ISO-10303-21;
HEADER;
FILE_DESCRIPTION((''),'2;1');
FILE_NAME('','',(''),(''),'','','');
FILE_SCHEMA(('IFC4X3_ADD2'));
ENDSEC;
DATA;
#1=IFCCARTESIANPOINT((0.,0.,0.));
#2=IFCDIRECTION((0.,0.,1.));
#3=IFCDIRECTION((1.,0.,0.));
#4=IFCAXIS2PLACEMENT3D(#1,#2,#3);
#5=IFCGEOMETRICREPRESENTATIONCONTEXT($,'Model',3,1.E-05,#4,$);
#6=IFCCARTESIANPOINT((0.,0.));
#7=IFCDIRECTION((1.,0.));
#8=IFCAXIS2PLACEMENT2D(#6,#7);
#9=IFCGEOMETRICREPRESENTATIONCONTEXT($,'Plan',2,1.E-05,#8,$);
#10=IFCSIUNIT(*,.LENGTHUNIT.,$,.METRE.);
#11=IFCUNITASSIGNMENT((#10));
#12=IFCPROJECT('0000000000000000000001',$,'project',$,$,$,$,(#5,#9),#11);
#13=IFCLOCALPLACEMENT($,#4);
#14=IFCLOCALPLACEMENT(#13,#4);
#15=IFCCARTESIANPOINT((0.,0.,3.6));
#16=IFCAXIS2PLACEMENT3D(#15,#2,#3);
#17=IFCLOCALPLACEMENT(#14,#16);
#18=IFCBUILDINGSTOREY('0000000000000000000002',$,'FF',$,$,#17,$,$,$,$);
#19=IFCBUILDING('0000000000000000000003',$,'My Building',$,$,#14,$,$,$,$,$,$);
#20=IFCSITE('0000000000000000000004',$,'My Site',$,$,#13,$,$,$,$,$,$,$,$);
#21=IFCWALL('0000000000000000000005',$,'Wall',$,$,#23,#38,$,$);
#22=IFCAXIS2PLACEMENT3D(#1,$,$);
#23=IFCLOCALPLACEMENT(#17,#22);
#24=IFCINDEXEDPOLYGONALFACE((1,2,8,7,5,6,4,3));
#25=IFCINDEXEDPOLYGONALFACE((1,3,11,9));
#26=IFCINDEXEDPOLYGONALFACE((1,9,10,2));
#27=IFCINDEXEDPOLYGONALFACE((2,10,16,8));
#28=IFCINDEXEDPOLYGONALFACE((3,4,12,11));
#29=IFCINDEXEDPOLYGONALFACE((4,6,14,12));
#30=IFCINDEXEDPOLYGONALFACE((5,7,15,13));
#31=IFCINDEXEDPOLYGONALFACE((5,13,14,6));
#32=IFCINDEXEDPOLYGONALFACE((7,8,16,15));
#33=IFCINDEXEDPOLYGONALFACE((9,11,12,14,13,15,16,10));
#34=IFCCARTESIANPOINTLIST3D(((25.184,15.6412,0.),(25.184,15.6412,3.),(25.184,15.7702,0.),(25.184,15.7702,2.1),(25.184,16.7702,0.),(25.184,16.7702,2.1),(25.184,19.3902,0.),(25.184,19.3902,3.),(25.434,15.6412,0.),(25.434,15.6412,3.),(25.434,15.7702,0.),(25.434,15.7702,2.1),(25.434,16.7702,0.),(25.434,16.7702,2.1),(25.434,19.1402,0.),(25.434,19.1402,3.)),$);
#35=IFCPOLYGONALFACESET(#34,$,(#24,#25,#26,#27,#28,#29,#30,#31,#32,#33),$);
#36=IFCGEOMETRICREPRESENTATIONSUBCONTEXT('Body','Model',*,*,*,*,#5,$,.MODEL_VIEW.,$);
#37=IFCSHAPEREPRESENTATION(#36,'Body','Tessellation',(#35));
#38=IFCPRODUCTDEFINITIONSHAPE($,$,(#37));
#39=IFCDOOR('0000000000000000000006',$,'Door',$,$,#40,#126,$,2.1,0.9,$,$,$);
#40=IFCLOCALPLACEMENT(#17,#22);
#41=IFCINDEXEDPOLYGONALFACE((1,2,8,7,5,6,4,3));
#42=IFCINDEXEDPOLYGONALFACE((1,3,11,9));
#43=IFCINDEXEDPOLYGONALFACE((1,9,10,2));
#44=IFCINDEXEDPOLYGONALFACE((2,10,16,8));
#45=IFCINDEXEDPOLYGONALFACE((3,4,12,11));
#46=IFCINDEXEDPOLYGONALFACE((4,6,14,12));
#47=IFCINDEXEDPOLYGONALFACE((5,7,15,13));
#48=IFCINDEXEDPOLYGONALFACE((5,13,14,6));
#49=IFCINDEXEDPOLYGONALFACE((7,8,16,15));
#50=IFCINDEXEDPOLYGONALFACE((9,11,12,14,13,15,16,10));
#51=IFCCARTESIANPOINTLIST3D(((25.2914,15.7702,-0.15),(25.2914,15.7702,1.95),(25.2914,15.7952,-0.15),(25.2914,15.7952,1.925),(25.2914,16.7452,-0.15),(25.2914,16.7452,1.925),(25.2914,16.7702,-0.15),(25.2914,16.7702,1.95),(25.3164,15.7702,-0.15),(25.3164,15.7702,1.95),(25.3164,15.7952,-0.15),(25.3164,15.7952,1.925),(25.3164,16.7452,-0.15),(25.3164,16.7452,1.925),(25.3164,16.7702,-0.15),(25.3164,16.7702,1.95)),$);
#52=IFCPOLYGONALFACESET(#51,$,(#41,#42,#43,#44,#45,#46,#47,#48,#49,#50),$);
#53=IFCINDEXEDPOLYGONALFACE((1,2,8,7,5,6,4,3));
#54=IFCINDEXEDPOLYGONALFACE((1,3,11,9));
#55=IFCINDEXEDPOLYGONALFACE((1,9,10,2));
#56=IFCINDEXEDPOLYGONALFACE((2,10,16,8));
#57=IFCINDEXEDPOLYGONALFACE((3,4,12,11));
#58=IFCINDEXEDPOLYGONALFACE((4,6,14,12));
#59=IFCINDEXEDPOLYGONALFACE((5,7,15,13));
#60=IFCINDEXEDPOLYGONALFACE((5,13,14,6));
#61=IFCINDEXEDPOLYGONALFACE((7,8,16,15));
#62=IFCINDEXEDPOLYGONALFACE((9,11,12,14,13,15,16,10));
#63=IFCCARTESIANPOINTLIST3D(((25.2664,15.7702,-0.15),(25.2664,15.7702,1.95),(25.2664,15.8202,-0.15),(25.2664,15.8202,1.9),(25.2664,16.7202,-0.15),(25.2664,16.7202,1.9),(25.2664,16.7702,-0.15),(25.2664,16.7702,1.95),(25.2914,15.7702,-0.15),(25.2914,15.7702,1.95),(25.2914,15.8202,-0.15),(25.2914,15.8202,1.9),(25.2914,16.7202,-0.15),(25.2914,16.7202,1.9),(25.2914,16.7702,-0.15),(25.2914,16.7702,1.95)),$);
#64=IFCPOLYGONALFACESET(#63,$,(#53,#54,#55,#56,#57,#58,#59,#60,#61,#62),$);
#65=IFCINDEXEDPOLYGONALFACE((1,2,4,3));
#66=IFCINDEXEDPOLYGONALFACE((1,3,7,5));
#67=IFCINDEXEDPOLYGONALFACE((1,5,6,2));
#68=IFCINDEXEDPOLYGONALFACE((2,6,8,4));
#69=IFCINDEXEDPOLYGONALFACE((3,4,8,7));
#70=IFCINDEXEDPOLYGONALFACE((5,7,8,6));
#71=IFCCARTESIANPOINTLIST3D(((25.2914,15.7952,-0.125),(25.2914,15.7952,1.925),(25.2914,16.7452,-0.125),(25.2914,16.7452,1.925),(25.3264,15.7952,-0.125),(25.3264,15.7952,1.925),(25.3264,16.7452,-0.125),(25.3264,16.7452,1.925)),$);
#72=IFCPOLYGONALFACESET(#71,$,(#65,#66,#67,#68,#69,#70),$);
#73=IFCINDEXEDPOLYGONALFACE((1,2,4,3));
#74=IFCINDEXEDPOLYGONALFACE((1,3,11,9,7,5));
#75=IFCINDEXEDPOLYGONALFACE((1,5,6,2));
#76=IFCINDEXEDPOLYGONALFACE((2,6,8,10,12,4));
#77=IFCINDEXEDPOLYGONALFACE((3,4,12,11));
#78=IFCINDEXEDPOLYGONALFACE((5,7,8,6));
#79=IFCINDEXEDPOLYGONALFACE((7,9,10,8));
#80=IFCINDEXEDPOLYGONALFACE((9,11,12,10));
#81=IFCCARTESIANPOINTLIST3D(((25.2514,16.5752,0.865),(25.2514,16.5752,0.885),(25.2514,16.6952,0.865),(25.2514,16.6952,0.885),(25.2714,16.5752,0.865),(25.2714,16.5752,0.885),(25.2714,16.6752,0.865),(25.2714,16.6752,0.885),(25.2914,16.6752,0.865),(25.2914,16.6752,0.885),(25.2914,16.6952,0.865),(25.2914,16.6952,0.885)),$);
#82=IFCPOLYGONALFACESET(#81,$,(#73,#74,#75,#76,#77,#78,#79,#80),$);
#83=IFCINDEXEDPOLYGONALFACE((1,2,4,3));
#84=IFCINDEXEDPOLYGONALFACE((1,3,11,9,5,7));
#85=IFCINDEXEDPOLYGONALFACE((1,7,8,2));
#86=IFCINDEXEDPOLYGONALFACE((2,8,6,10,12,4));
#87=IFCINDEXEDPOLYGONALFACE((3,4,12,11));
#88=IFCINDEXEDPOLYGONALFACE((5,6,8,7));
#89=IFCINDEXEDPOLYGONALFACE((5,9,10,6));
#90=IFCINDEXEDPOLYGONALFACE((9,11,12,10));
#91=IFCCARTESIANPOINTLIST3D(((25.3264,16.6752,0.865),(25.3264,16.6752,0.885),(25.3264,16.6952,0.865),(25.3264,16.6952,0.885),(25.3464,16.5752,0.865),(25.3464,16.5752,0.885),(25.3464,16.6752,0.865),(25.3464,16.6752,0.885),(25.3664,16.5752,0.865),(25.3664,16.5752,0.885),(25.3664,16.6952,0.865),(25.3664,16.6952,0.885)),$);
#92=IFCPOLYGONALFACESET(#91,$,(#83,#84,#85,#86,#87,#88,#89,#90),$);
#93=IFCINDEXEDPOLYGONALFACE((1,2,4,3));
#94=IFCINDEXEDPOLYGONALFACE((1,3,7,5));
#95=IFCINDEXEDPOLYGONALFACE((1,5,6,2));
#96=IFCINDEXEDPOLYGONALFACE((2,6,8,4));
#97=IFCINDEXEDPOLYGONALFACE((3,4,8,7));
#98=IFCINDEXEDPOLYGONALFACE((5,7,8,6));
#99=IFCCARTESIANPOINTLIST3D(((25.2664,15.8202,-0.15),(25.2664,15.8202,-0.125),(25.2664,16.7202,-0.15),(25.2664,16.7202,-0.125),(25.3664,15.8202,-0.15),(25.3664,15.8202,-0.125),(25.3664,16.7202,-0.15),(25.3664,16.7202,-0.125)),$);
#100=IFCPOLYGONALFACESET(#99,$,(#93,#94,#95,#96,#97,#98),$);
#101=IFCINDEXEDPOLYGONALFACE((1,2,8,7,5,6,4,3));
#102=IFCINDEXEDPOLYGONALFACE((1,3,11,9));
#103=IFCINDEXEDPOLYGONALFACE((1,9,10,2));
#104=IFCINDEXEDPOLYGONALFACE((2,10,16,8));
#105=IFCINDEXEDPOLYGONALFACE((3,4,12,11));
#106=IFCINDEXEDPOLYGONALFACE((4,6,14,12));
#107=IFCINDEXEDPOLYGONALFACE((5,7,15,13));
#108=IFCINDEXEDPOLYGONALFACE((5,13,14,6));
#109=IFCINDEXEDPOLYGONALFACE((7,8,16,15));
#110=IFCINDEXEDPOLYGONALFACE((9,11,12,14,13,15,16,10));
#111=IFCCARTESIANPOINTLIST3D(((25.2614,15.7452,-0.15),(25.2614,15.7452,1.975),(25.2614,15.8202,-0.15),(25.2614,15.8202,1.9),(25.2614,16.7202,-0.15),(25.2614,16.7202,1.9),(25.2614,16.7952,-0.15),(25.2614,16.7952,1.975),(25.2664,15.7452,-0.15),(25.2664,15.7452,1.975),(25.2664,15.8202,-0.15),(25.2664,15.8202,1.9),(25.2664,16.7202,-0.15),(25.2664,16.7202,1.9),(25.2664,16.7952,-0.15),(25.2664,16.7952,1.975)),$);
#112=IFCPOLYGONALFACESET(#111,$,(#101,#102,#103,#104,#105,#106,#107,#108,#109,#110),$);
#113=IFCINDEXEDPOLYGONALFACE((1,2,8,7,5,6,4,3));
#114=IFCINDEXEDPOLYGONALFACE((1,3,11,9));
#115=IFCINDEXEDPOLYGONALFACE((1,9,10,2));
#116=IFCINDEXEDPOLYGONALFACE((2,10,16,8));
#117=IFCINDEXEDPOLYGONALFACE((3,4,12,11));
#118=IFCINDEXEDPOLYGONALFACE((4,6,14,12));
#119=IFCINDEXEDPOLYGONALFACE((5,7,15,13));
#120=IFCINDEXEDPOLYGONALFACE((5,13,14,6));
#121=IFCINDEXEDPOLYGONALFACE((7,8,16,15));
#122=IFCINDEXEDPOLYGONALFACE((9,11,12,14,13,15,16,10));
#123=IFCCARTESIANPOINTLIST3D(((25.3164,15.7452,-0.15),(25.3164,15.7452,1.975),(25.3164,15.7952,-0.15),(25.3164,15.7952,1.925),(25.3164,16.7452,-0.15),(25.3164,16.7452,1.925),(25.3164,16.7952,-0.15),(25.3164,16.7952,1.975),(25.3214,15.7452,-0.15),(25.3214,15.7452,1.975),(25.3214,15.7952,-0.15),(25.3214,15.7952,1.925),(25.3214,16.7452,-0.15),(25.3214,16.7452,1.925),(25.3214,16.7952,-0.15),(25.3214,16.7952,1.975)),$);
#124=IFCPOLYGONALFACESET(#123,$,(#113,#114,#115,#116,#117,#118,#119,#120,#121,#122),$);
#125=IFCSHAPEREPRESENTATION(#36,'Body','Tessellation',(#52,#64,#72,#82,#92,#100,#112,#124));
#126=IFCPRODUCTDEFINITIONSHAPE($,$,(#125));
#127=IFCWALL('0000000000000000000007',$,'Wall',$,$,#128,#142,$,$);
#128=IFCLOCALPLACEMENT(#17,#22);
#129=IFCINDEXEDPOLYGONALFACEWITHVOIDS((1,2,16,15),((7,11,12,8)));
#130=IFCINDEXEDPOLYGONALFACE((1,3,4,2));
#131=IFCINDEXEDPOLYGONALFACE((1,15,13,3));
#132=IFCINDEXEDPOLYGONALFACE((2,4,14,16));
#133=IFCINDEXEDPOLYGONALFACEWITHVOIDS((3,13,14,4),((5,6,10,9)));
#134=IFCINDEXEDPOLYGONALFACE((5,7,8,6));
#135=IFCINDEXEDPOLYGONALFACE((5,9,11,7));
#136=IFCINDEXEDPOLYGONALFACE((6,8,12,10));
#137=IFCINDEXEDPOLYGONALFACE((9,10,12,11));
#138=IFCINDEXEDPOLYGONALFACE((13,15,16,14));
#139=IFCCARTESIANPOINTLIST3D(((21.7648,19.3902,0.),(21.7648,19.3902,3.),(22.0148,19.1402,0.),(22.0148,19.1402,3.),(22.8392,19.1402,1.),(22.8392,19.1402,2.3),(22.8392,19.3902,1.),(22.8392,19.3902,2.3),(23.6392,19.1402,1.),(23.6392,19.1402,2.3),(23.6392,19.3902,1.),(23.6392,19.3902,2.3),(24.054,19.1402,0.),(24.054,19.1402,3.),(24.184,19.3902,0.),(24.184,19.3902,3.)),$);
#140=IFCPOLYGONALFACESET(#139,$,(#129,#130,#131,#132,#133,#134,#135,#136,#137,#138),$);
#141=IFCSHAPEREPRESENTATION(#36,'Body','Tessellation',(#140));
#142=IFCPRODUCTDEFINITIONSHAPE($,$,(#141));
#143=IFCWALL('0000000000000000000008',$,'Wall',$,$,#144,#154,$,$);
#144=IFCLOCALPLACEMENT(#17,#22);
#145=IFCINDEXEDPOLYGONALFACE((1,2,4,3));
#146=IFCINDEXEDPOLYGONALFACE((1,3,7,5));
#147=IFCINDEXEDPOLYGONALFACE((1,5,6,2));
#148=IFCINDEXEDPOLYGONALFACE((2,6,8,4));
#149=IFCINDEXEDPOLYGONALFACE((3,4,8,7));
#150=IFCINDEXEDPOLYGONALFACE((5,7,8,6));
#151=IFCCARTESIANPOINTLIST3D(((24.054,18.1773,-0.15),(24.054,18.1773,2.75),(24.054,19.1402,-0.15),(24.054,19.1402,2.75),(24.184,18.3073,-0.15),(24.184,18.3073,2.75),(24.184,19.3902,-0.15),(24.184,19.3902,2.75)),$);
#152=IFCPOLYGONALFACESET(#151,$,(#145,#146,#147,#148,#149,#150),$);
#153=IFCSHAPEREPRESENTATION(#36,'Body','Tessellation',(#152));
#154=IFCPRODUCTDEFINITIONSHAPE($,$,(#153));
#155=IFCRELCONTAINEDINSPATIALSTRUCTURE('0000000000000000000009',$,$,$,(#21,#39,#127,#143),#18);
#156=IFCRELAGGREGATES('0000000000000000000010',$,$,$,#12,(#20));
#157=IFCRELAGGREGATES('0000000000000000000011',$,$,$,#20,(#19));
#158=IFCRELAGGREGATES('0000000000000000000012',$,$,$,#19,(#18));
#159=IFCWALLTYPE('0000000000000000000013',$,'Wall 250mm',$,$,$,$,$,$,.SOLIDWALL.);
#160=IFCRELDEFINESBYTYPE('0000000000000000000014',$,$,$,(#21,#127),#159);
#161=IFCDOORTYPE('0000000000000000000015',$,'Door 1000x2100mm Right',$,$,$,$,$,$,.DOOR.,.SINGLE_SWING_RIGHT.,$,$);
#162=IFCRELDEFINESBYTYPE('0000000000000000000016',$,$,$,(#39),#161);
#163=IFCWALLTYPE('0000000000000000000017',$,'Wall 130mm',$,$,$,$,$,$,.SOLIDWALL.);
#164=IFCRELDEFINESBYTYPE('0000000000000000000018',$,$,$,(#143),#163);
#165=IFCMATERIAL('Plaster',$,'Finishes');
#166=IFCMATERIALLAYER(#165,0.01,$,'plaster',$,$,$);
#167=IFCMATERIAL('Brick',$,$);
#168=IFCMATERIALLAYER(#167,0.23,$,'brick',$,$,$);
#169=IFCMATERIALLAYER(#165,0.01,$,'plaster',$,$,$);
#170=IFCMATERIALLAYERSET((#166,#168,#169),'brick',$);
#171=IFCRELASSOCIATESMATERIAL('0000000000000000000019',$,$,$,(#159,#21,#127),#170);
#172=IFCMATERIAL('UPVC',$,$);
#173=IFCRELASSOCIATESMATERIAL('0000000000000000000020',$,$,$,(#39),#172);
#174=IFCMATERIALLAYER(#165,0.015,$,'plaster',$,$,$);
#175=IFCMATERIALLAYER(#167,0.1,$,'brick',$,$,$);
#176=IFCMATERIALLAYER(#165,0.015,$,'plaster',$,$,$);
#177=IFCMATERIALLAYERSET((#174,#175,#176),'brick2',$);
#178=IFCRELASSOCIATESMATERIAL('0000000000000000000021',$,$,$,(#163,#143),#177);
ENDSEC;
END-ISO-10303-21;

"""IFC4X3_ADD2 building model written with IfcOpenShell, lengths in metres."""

from ifc_helpers import new_model, entity, si_unit, frame, origin_with_axes, origin_2d_with_axis, place, context, subcontext, project, spatial, line, indexed_curve, outline, extrude, shape, source, transform, mapped, material, layer, layer_set, layer_usage, type_object, type_shapes, element, fill, save


model = new_model("IFC4X3_ADD2")

# Units and contexts
model_context = context("Model", 3, precision=1e-05, world=origin_with_axes())
plan_context = context("Plan", 2, precision=1e-05, world=origin_2d_with_axis())
body_context_1 = subcontext(model_context, "Body", "Model", "MODEL_VIEW")
body_context_2 = subcontext(plan_context, "Body", "Plan", "PLAN_VIEW")
ifc_project = project(units=[si_unit("LENGTHUNIT", "METRE")], contexts=[model_context, plan_context])

# Site, building, storey
site_placement = place(None, origin_with_axes())
site = spatial("IfcSite", under=ifc_project, at=site_placement, Name="My Site")
building_placement = place(site_placement, origin_with_axes())
building = spatial("IfcBuilding", under=site, at=building_placement, Name="My Building")
storey_placement = place(building_placement, frame((0.0, 0.0, 3.6), z_axis=(0.0, 0.0, 1.0), x_axis=(1.0, 0.0, 0.0)))
storey = spatial("IfcBuildingStorey", under=building, at=storey_placement, Name="FF")

# Shared definitions
ifc_material_1 = material(Name="UPVC")

# Shared definitions
ifc_material_2 = material(Name="Plaster", Category="Finishes")
ifc_layer_1 = layer(ifc_material_2, 0.01, Name="plaster")
ifc_material_3 = material(Name="Brick")
ifc_layer_2 = layer(ifc_material_3, 0.23, Name="brick")
ifc_layer_3 = layer(ifc_material_2, 0.01, Name="plaster")
ifc_layer_set_1 = layer_set([ifc_layer_1, ifc_layer_2, ifc_layer_3], Name="brick")
wall_type_1 = type_object("IfcWallType", Name="Wall 250mm", PredefinedType="SOLIDWALL", material=ifc_layer_set_1)
shared_shape_1 = source(origin_with_axes(), body_context_1, "Body", "SweptSolid", [
    extrude(outline(indexed_curve([(0.0, 0.0), (0.8, 0.0), (0.8, 1.3), (0.0, 1.3)], segments=[line(1, 2, 3, 4, 1)])), frame((-0.4, -0.6, 0.0), z_axis=(0.0, -1.0, 0.0), x_axis=(1.0, 0.0, 0.0)), (0.0, 0.0, -1.0), 1.2),
])

# Wall, opening, door
ifc_layer_usage_1 = layer_usage(ifc_layer_set_1, "AXIS2", "POSITIVE", 0.0)
wall_1_placement = place(storey_placement, frame((25.434, 15.3912, 0.0), z_axis=(0.0, 0.0, 1.0), x_axis=(0.000001, 1.0, 0.0)))
wall_1 = element("IfcWall", 1, at=wall_1_placement, inside=storey, type_object=wall_type_1, material=ifc_layer_usage_1, Name="Wall", context=body_context_1, shape_type="SweptSolid", body=[
    extrude(outline(indexed_curve([(0.25, 0.0), (0.25, 0.25), (3.999, 0.25), (3.749, 0.0)], segments=[line(1, 2, 3, 4, 1)])), origin_with_axes(), (0.0, 0.0, 1.0), 3.0),
])
shared_shape_2 = source(origin_with_axes(), body_context_1, "Body", "SweptSolid", [
    extrude(outline(indexed_curve([(0.0, 2.1), (1.0, 2.1), (1.0, -0.05), (0.0, -0.05), (0.0, 2.1)])), frame((0.0, -0.6, 0.0), z_axis=(0.0, -1.0, 0.0), x_axis=(1.0, 0.0, 0.0)), (0.0, 0.0, -1.0), 1.2),
])
opening_1_placement = place(wall_1_placement, frame((1.379, 0.1676, 0.0), z_axis=(0.0, 0.0, 1.0), x_axis=(-1.0, 0.0, 0.0)))
opening_1 = element("IfcOpeningElement", 2, at=opening_1_placement, cuts=wall_1, PredefinedType="OPENING", context=body_context_1, shape_type="MappedRepresentation", body=[
    mapped(shared_shape_2, transform((0.0, 0.0, 0.0), x_axis=(1.0, 0.0, 0.0), y_axis=(0.0, 1.0, 0.0), z_axis=(0.0, 0.0, 1.0), scale=1.0)),
])
door_type_1 = type_object("IfcDoorType", Name="Door 1000x2100mm Right", OperationType="SINGLE_SWING_RIGHT", PredefinedType="DOOR")
shared_shape_3 = source(origin_with_axes(), body_context_1, "Body", "SweptSolid", [
    extrude(outline(indexed_curve([(0.0, 0.0), (0.0, 2.1), (1.0, 2.1), (1.0, 0.0), (0.975, 0.0), (0.975, 2.075), (0.025, 2.075), (0.025, 0.0)], segments=[line(1, 2, 3, 4, 5, 6, 7, 8, 1)])), frame((0.0, 0.025, 0.0), z_axis=(0.0, -1.0, 0.0), x_axis=(1.0, 0.0, 0.0)), (0.0, 0.0, -1.0), 0.025),
    extrude(outline(indexed_curve([(0.0, 0.0), (0.0, 2.1), (1.0, 2.1), (1.0, 0.0), (0.95, 0.0), (0.95, 2.05), (0.05, 2.05), (0.05, 0.0)], segments=[line(1, 2, 3, 4, 5, 6, 7, 8, 1)])), frame((0.0, 0.0, 0.0), z_axis=(0.0, -1.0, 0.0), x_axis=(1.0, 0.0, 0.0)), (0.0, 0.0, -1.0), 0.025),
    extrude(outline(indexed_curve([(0.0, 0.0), (0.95, 0.0), (0.95, 0.035), (0.0, 0.035)], segments=[line(1, 2, 3, 4, 1)])), frame((0.025, 0.025, 0.025), z_axis=(0.0, 0.0, 1.0), x_axis=(1.0, 0.0, 0.0)), (0.0, 0.0, 1.0), 2.05),
    extrude(outline(indexed_curve([(0.0, 0.0), (0.0, -0.04), (0.12, -0.04), (0.12, -0.02), (0.02, -0.02), (0.02, 0.0)], segments=[line(1, 2, 3, 4, 5, 6, 1)])), frame((0.075, 0.025, 1.015), z_axis=(0.0, 0.0, 1.0), x_axis=(1.0, 0.0, 0.0)), (0.0, 0.0, 1.0), 0.02),
    extrude(outline(indexed_curve([(0.0, 0.0), (0.0, 0.04), (0.12, 0.04), (0.12, 0.02), (0.02, 0.02), (0.02, 0.0)], segments=[line(1, 2, 3, 4, 5, 6, 1)])), frame((0.075, 0.06, 1.015), z_axis=(0.0, 0.0, 1.0), x_axis=(1.0, 0.0, 0.0)), (0.0, 0.0, 1.0), 0.02),
    extrude(outline(indexed_curve([(0.0, 0.0), (0.9, 0.0), (0.9, 0.1), (0.0, 0.1)], segments=[line(1, 2, 3, 4, 1)])), frame((0.05, 0.0, 0.0), z_axis=(0.0, 0.0, 1.0), x_axis=(1.0, 0.0, 0.0)), (0.0, 0.0, 1.0), 0.025),
    extrude(outline(indexed_curve([(0.0, 0.0), (0.0, 2.125), (1.05, 2.125), (1.05, 0.0), (0.975, 0.0), (0.975, 2.05), (0.075, 2.05), (0.075, 0.0)], segments=[line(1, 2, 3, 4, 5, 6, 7, 8, 1)])), frame((-0.025, -0.005, 0.0), z_axis=(0.0, -1.0, 0.0), x_axis=(1.0, 0.0, 0.0)), (0.0, 0.0, -1.0), 0.005),
    extrude(outline(indexed_curve([(0.0, 0.0), (0.0, 2.125), (1.05, 2.125), (1.05, 0.0), (1.0, 0.0), (1.0, 2.075), (0.05, 2.075), (0.05, 0.0)], segments=[line(1, 2, 3, 4, 5, 6, 7, 8, 1)])), frame((-0.025, 0.05, 0.0), z_axis=(0.0, -1.0, 0.0), x_axis=(1.0, 0.0, 0.0)), (0.0, 0.0, -1.0), 0.005),
])
shared_shape_4 = source(origin_with_axes(), body_context_2, "Body", "Curve2D", [
    entity("IfcIndexedPolyCurve", entity("IfcCartesianPointList2D", [[0.0, 0.0], [0.0, 0.05], [0.025, 0.05], [0.025, 0.025], [0.05, 0.025], [0.05, 0.0]]), [entity("IfcLineIndex", [1, 2, 3, 4, 5, 6, 1])]),
    entity("IfcIndexedPolyCurve", entity("IfcCartesianPointList2D", [[1.0, 0.0], [1.0, 0.05], [0.975, 0.05], [0.975, 0.025], [0.95, 0.025], [0.95, 0.0]]), [entity("IfcLineIndex", [1, 2, 3, 4, 5, 6, 1])]),
    entity("IfcTrimmedCurve", entity("IfcEllipse", entity("IfcAxis2Placement2D", entity("IfcCartesianPoint", [0.94, 0.05]), entity("IfcDirection", [1.0, 0.0])), 0.915, 0.95), [entity("IfcCartesianPoint", [0.94, 1.0])], [entity("IfcCartesianPoint", [0.025, 0.05])], True, "CARTESIAN"),
    entity("IfcIndexedPolyCurve", entity("IfcCartesianPointList2D", [[0.975, 0.05], [0.94, 0.05], [0.94, 1.0], [0.975, 1.0]]), [entity("IfcLineIndex", [1, 2, 3, 4, 1])]),
])
type_shapes(door_type_1, [shared_shape_3, shared_shape_4])
door_1_placement = place(opening_1_placement, frame((0.0, 0.0, -0.15), z_axis=(0.0, 0.0, 1.0), x_axis=(1.0, 0.0, 0.0)))
door_1 = element("IfcDoor", 3, at=door_1_placement, inside=storey, type_object=door_type_1, material=ifc_material_1, Name="Door", OverallHeight=2.1, OverallWidth=0.9, shapes=[
    shape(body_context_1, "Body", "MappedRepresentation", [mapped(shared_shape_3, transform((0.0, 0.0, 0.0), x_axis=(1.0, 0.0, 0.0), y_axis=(0.0, 1.0, 0.0), z_axis=(0.0, 0.0, 1.0), scale=1.0))]),
    shape(body_context_2, "Body", "MappedRepresentation", [mapped(shared_shape_4, transform((0.0, 0.0, 0.0), x_axis=(1.0, 0.0, 0.0), y_axis=(0.0, 1.0, 0.0), z_axis=(0.0, 0.0, 1.0), scale=1.0))]),
])
fill(opening_1, door_1)

# Wall, opening
ifc_layer_usage_2 = layer_usage(ifc_layer_set_1, "AXIS2", "POSITIVE", 0.0)
wall_2_placement = place(storey_placement, frame((24.184, 19.3902, 0.0), z_axis=(0.0, 0.0, 1.0), x_axis=(-1.0, 0.0, 0.0)))
wall_2 = element("IfcWall", 4, at=wall_2_placement, inside=storey, type_object=wall_type_1, material=ifc_layer_usage_2, Name="Wall", context=body_context_1, shape_type="SweptSolid", body=[
    extrude(outline(indexed_curve([(0.0, 0.0), (0.13, 0.25), (2.1692, 0.25), (2.4192, 0.0)], segments=[line(1, 2, 3, 4, 1)])), origin_with_axes(), (0.0, 0.0, 1.0), 3.0),
])
opening_2_placement = place(wall_2_placement, frame((0.9448, 0.0, 1.0), z_axis=(0.0, 0.0, 1.0), x_axis=(1.0, 0.0, 0.0)))
element("IfcOpeningElement", 5, at=opening_2_placement, cuts=wall_2, PredefinedType="OPENING", context=body_context_1, shape_type="MappedRepresentation", body=[
    mapped(shared_shape_1, transform((0.0, 0.0, 0.0), x_axis=(1.0, 0.0, 0.0), y_axis=(0.0, 1.0, 0.0), z_axis=(0.0, 0.0, 1.0), scale=1.0)),
])

# Wall
ifc_layer_4 = layer(ifc_material_2, 0.015, Name="plaster")
ifc_layer_5 = layer(ifc_material_3, 0.1, Name="brick")
ifc_layer_6 = layer(ifc_material_2, 0.015, Name="plaster")
ifc_layer_set_2 = layer_set([ifc_layer_4, ifc_layer_5, ifc_layer_6], Name="brick2")
ifc_layer_usage_3 = layer_usage(ifc_layer_set_2, "AXIS2", "POSITIVE", 0.0)
wall_type_2 = type_object("IfcWallType", Name="Wall 130mm", PredefinedType="SOLIDWALL", material=ifc_layer_set_2)
wall_3_placement = place(storey_placement, frame((24.184, 18.3073, -0.15), z_axis=(0.0, 0.0, 1.0), x_axis=(0.000001, 1.0, 0.0)))
element("IfcWall", 6, at=wall_3_placement, inside=storey, type_object=wall_type_2, material=ifc_layer_usage_3, Name="Wall", context=body_context_1, shape_type="SweptSolid", body=[
    extrude(outline(indexed_curve([(0.0, 0.0), (-0.13, 0.13), (0.8329, 0.13), (1.0829, 0.0)], segments=[line(1, 2, 3, 4, 1)])), origin_with_axes(), (0.0, 0.0, 1.0), 2.9),
])

save(model, "model.ifc")
